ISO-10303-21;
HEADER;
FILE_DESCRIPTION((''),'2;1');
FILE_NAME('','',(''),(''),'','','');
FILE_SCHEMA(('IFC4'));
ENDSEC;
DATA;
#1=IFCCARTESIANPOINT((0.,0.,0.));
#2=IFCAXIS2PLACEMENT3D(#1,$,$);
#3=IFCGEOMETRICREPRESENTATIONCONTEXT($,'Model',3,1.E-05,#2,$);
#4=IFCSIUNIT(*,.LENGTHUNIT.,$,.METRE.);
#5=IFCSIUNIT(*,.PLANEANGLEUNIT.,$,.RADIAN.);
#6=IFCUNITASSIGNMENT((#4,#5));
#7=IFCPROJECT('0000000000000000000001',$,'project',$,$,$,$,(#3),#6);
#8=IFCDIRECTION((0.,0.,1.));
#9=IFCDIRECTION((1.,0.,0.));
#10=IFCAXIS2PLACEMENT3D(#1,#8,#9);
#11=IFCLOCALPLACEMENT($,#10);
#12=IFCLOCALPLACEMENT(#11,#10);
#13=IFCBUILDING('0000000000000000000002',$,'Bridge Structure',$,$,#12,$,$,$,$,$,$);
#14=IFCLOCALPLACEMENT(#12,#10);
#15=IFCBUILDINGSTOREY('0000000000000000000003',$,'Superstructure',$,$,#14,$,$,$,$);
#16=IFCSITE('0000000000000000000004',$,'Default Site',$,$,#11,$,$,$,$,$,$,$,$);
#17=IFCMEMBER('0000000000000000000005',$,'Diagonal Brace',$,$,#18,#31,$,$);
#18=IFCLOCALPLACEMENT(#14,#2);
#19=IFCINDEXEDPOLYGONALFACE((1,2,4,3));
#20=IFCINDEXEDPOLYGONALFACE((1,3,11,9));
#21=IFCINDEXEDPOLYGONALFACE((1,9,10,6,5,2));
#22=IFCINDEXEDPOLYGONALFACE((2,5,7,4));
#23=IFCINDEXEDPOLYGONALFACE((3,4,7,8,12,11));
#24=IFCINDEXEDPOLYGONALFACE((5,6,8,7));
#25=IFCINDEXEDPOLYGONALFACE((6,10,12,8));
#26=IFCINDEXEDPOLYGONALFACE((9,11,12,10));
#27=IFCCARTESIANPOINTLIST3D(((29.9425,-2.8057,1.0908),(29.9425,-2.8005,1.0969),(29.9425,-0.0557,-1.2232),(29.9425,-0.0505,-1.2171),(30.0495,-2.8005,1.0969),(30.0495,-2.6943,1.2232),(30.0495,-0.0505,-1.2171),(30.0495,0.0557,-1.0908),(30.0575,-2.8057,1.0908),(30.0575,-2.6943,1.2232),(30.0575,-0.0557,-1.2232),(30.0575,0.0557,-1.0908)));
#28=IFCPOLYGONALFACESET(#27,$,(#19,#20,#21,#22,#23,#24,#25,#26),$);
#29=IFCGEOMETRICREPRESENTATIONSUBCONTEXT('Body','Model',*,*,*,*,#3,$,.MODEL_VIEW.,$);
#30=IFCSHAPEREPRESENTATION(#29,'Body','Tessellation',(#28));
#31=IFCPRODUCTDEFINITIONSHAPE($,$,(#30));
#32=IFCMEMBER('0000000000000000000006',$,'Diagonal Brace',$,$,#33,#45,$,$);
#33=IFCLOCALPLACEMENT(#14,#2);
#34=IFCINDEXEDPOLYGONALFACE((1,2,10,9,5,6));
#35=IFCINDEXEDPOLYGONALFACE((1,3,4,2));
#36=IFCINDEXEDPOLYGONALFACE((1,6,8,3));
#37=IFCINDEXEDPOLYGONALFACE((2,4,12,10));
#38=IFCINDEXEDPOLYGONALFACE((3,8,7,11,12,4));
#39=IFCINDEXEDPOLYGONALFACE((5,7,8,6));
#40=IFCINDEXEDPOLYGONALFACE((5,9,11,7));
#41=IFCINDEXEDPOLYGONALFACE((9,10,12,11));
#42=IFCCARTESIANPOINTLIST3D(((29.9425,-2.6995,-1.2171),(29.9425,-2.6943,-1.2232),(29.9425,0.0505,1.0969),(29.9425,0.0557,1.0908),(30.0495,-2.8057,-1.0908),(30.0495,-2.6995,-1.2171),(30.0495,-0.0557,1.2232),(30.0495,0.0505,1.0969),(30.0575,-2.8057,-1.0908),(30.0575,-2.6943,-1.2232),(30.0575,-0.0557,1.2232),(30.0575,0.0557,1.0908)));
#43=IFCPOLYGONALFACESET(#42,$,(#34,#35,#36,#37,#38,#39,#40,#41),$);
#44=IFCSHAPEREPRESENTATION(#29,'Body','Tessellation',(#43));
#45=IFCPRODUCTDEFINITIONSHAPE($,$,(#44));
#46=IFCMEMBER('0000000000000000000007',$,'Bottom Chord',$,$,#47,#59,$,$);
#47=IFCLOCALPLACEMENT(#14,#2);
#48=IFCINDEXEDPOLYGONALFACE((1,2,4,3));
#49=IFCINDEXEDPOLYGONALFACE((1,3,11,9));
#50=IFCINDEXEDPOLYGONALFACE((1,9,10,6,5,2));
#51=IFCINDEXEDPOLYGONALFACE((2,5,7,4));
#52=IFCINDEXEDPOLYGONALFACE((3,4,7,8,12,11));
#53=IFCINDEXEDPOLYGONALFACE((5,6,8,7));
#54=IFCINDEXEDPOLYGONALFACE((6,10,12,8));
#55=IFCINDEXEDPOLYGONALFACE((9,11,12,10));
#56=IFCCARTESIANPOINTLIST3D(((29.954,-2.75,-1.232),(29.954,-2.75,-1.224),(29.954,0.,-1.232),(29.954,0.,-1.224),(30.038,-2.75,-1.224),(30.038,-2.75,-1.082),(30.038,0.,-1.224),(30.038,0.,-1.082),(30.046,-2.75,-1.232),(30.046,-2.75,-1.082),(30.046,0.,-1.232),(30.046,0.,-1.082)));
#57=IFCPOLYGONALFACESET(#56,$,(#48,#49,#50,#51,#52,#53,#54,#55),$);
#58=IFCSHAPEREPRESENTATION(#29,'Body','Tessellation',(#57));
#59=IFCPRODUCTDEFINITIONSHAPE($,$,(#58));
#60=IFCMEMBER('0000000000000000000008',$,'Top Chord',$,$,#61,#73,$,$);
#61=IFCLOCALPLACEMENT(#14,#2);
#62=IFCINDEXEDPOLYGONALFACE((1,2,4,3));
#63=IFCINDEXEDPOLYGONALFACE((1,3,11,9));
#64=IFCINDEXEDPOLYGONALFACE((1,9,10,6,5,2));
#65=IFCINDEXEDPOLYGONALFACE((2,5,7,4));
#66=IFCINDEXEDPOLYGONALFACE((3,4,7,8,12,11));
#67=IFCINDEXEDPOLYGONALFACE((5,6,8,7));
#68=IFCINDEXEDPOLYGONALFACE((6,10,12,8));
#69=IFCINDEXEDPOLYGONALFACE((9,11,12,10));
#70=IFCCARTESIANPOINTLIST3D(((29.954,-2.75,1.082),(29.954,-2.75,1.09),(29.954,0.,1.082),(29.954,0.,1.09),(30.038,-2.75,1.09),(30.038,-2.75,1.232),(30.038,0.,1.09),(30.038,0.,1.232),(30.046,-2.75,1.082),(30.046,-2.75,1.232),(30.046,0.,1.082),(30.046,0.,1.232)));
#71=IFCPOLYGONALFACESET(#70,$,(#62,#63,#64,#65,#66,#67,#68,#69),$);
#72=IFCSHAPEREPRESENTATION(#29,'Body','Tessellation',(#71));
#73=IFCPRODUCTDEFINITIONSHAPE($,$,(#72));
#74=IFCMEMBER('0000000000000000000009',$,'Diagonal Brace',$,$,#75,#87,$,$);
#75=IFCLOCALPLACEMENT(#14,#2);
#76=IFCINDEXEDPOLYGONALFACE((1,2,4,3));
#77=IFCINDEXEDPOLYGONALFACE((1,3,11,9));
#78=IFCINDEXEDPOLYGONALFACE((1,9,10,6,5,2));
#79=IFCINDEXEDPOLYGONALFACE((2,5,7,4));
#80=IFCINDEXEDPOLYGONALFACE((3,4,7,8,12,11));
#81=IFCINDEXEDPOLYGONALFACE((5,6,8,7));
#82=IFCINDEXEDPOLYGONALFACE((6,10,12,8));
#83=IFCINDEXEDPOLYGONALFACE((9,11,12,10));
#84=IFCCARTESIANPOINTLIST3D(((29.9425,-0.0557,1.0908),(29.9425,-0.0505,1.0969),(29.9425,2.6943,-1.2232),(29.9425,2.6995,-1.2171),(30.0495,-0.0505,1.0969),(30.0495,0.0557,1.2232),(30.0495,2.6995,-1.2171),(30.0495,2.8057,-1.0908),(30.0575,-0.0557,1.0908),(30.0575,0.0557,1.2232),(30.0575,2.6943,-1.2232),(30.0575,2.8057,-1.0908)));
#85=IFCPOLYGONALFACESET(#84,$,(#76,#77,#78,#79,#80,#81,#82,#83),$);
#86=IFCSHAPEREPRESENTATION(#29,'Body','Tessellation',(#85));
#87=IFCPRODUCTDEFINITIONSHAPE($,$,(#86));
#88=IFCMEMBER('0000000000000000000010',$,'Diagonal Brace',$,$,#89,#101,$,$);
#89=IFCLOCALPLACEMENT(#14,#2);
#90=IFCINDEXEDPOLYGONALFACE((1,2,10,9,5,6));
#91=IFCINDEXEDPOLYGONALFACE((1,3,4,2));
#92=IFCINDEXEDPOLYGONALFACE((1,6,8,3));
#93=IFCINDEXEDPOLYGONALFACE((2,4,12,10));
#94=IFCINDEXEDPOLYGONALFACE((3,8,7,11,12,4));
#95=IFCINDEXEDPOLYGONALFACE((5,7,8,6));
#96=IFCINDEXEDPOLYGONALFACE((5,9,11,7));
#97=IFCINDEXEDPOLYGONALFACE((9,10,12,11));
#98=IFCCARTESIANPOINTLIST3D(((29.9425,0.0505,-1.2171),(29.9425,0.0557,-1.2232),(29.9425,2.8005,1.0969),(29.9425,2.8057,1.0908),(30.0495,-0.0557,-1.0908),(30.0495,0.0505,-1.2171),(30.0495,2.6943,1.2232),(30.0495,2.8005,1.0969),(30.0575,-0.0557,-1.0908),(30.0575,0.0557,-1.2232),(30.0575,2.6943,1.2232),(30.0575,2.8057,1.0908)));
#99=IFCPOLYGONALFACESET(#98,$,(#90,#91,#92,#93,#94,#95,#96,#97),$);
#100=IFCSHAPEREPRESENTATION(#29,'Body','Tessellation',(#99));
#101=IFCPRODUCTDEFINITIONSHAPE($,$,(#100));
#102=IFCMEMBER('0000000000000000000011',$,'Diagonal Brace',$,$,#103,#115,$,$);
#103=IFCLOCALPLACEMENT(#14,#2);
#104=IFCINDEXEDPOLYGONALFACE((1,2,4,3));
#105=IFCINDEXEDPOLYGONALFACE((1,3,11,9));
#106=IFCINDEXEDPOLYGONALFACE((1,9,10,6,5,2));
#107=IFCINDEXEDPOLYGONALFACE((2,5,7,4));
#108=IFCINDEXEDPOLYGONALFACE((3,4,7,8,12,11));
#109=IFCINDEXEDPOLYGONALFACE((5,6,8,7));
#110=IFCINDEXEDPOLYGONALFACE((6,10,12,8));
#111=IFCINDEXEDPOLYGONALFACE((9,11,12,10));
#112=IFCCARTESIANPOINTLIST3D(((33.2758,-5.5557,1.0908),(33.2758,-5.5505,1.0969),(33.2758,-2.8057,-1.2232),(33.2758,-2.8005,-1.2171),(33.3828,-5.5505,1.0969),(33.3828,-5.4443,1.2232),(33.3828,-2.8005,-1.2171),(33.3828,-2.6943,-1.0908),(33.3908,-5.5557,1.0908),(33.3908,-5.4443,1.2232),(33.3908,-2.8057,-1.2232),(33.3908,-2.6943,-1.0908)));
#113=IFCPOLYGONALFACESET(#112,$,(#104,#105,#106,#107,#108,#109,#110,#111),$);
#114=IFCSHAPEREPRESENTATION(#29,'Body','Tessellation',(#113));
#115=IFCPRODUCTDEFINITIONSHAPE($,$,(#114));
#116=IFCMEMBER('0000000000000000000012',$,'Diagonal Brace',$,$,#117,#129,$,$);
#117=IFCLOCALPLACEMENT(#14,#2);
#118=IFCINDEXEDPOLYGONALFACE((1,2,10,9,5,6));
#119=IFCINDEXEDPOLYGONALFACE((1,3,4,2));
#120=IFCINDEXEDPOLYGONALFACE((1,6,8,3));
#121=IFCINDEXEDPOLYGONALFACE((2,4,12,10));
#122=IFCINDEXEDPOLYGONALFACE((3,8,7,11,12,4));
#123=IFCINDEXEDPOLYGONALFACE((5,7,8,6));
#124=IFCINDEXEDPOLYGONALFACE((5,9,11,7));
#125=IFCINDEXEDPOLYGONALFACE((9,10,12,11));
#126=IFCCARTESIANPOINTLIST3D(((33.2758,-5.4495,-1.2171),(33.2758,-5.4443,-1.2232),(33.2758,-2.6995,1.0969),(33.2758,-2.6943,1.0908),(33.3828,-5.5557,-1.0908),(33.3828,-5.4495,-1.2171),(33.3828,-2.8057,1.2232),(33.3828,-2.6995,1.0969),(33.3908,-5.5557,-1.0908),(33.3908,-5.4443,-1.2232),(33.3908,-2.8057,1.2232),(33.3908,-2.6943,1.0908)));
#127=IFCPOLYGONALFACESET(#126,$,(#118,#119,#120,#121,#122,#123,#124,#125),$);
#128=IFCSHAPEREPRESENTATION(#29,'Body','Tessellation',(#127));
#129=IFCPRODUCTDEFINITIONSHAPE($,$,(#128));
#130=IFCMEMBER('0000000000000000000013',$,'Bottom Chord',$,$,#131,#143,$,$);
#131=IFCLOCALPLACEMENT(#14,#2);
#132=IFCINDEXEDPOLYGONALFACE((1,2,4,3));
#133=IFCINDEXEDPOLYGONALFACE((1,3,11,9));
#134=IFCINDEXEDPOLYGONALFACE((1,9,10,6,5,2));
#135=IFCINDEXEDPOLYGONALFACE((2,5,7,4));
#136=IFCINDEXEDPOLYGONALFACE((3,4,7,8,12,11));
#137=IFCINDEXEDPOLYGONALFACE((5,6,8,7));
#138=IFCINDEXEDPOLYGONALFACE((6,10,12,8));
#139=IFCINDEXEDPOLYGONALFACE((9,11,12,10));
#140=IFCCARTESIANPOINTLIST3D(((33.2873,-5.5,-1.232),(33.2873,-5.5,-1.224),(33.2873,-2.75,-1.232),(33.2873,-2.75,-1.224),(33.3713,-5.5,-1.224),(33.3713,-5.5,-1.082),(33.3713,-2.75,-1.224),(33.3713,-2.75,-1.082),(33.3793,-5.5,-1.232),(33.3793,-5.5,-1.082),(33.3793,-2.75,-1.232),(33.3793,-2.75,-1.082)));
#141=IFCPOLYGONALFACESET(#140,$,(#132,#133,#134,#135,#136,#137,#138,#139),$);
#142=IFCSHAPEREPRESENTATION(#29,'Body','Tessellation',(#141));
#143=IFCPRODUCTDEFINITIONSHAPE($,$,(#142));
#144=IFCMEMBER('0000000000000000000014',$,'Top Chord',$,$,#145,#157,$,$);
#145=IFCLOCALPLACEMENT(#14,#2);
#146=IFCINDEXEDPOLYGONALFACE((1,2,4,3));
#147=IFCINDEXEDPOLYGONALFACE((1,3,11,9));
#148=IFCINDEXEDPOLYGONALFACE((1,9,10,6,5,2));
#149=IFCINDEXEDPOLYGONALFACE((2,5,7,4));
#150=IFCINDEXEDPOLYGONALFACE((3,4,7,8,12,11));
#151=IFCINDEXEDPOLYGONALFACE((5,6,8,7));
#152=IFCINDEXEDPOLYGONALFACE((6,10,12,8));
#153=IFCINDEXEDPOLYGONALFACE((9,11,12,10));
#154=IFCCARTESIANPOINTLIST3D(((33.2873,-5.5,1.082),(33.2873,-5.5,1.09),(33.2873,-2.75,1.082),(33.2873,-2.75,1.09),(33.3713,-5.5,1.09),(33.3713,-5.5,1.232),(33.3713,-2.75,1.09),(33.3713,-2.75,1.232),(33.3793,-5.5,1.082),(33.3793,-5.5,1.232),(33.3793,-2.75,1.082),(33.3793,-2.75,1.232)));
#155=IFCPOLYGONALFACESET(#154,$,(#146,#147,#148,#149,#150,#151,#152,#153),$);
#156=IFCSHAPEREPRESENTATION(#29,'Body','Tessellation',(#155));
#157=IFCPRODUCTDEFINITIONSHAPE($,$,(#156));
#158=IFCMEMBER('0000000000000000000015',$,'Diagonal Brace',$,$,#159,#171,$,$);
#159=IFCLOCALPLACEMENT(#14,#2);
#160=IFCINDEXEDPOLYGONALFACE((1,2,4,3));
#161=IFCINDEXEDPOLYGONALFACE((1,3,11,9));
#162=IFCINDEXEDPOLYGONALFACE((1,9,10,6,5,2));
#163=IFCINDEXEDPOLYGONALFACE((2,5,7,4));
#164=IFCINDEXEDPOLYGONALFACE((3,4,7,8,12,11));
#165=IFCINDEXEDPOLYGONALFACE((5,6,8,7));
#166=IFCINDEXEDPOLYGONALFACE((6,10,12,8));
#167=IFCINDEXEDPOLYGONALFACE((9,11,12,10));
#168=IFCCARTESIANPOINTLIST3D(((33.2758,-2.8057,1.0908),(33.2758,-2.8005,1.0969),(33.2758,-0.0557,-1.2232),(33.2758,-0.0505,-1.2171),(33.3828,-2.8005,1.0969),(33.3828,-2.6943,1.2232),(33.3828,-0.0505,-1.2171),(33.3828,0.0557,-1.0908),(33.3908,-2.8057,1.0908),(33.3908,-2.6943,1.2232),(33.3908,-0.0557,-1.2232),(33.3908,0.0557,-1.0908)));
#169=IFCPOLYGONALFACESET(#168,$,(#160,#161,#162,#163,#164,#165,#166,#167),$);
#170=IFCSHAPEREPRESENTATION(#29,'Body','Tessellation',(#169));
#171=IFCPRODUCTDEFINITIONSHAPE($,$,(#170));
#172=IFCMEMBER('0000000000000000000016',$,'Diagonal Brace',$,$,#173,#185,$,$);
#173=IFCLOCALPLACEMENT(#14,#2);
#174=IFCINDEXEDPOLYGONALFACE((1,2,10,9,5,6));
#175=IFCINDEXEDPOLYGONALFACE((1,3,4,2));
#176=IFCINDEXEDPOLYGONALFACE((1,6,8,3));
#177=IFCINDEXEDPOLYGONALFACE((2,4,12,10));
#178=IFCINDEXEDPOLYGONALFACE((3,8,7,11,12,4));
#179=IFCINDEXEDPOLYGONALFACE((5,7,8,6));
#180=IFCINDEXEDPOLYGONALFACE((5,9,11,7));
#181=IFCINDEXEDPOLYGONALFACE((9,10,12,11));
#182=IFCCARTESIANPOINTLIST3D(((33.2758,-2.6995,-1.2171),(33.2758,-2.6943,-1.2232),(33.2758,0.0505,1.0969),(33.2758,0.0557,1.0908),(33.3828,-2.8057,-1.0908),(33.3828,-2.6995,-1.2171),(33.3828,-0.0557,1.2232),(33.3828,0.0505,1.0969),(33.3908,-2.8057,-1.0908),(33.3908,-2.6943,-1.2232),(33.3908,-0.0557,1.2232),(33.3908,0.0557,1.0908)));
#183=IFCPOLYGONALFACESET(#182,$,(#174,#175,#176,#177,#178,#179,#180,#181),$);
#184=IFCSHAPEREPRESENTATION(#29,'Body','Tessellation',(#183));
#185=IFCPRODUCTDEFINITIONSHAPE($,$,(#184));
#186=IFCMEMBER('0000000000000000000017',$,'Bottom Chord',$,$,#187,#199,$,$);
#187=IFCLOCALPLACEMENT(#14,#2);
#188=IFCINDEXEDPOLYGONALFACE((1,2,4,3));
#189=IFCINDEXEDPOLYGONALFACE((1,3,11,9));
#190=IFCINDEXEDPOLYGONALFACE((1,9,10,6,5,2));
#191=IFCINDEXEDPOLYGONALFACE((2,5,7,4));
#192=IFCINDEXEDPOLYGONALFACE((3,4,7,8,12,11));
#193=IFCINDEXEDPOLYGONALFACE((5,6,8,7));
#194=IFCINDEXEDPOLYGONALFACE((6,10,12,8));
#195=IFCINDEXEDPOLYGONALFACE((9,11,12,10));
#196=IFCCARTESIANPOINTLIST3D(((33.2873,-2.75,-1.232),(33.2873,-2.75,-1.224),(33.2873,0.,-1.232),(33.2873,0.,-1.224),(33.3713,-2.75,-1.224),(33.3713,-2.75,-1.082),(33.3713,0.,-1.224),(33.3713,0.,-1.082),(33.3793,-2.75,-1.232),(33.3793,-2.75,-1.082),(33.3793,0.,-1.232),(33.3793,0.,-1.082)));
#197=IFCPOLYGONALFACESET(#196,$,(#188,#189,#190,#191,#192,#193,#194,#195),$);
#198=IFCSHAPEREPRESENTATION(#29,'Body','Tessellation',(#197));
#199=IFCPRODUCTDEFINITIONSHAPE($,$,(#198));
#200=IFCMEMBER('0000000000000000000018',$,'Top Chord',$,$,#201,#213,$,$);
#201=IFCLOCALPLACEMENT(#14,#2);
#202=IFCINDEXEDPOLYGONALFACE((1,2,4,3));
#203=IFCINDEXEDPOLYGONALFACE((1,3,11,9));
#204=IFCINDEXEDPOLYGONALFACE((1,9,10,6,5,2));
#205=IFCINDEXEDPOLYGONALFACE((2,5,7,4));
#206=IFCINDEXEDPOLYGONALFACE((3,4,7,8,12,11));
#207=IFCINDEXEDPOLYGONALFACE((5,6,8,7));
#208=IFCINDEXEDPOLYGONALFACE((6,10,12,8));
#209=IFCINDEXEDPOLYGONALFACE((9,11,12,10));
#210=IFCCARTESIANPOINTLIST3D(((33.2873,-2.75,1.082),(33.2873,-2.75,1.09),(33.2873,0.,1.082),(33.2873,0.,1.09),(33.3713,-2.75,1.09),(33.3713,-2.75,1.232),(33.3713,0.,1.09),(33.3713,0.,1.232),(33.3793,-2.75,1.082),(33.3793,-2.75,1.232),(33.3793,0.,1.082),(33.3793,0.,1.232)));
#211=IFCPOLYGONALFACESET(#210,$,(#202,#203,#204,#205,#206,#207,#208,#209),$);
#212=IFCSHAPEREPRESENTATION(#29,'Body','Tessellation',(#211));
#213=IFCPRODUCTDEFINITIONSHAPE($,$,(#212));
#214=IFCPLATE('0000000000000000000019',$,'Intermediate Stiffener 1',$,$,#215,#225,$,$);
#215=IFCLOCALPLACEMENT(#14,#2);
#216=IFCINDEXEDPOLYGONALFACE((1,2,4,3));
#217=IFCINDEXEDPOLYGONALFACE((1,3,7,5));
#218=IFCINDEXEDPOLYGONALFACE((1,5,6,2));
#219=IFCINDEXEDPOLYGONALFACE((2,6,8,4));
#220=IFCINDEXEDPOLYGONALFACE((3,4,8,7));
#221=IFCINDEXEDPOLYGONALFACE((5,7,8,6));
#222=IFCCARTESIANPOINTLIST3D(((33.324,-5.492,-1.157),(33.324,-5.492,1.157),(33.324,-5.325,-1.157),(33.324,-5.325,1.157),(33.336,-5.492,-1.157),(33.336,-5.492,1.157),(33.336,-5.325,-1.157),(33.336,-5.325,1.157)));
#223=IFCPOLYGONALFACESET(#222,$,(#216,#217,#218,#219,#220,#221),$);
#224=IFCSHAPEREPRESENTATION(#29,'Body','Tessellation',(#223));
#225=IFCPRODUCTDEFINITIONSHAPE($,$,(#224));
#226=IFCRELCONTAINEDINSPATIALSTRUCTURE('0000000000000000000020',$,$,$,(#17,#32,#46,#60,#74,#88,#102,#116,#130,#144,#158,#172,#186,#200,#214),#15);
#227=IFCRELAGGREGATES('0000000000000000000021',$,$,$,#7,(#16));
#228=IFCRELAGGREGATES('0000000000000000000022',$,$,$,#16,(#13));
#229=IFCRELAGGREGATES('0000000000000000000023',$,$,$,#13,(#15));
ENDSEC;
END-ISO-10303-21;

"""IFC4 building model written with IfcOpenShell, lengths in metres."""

from ifc_helpers import new_model, si_unit, frame, origin, origin_with_axes, origin_2d_with_axis, place, context, subcontext, project, spatial, rectangle, l_section, extrude, element, save


model = new_model("IFC4")

# Units and contexts
model_context = context("Model", 3, precision=1e-05, world=origin())
body_context = subcontext(model_context, "Body", "Model", "MODEL_VIEW")
ifc_project = project(units=[si_unit("LENGTHUNIT", "METRE"), si_unit("PLANEANGLEUNIT", "RADIAN")], contexts=[model_context])

# Site, building, storey
site_placement = place(None, origin_with_axes())
site = spatial("IfcSite", under=ifc_project, at=site_placement, Name="Default Site")
building_placement = place(site_placement, origin_with_axes())
building = spatial("IfcBuilding", under=site, at=building_placement, Name="Bridge Structure")
storey_placement = place(building_placement, origin_with_axes())
storey = spatial("IfcBuildingStorey", under=building, at=storey_placement, Name="Superstructure")

# Members
for number, where, z_axis, x_axis, name in (
    (1, (30.0, -2.75, 1.157), (0.0, 0.765156, -0.643844), (-1.0, 0.0, 0.0), "Diagonal Brace"),
    (2, (30.0, -2.75, -1.157), (0.0, 0.765156, 0.643844), (-1.0, 0.0, 0.0), "Diagonal Brace"),
):
    element("IfcMember", number, at=place(storey_placement, frame(where, z_axis=z_axis, x_axis=x_axis)), inside=storey, Name=name, context=body_context, shape_type="SweptSolid", body=[
        extrude(l_section(Depth=0.173, Width=0.115, Thickness=0.008, at=origin_2d_with_axis()), origin_with_axes(), (0.0, 0.0, 1.0), 3.594),
    ])
for number, where, z_axis, x_axis, name in (
    (3, (30.0, -2.75, -1.157), (0.0, 1.0, 0.0), (-1.0, 0.0, 0.0), "Bottom Chord"),
    (4, (30.0, -2.75, 1.157), (0.0, 1.0, 0.0), (-1.0, 0.0, 0.0), "Top Chord"),
):
    element("IfcMember", number, at=place(storey_placement, frame(where, z_axis=z_axis, x_axis=x_axis)), inside=storey, Name=name, context=body_context, shape_type="SweptSolid", body=[
        extrude(l_section(Depth=0.15, Width=0.092, Thickness=0.008, at=origin_2d_with_axis()), origin_with_axes(), (0.0, 0.0, 1.0), 2.75),
    ])
for number, where, z_axis, x_axis, name in (
    (5, (30.0, 0.0, 1.157), (0.0, 0.765156, -0.643844), (-1.0, 0.0, 0.0), "Diagonal Brace"),
    (6, (30.0, 0.0, -1.157), (0.0, 0.765156, 0.643844), (-1.0, 0.0, 0.0), "Diagonal Brace"),
    (7, (33.3333, -5.5, 1.157), (0.0, 0.765156, -0.643844), (-1.0, 0.0, 0.0), "Diagonal Brace"),
    (8, (33.3333, -5.5, -1.157), (0.0, 0.765156, 0.643844), (-1.0, 0.0, 0.0), "Diagonal Brace"),
):
    element("IfcMember", number, at=place(storey_placement, frame(where, z_axis=z_axis, x_axis=x_axis)), inside=storey, Name=name, context=body_context, shape_type="SweptSolid", body=[
        extrude(l_section(Depth=0.173, Width=0.115, Thickness=0.008, at=origin_2d_with_axis()), origin_with_axes(), (0.0, 0.0, 1.0), 3.594),
    ])
for number, where, z_axis, x_axis, name in (
    (9, (33.3333, -5.5, -1.157), (0.0, 1.0, 0.0), (-1.0, 0.0, 0.0), "Bottom Chord"),
    (10, (33.3333, -5.5, 1.157), (0.0, 1.0, 0.0), (-1.0, 0.0, 0.0), "Top Chord"),
):
    element("IfcMember", number, at=place(storey_placement, frame(where, z_axis=z_axis, x_axis=x_axis)), inside=storey, Name=name, context=body_context, shape_type="SweptSolid", body=[
        extrude(l_section(Depth=0.15, Width=0.092, Thickness=0.008, at=origin_2d_with_axis()), origin_with_axes(), (0.0, 0.0, 1.0), 2.75),
    ])
for number, where, z_axis, x_axis, name in (
    (11, (33.3333, -2.75, 1.157), (0.0, 0.765156, -0.643844), (-1.0, 0.0, 0.0), "Diagonal Brace"),
    (12, (33.3333, -2.75, -1.157), (0.0, 0.765156, 0.643844), (-1.0, 0.0, 0.0), "Diagonal Brace"),
):
    element("IfcMember", number, at=place(storey_placement, frame(where, z_axis=z_axis, x_axis=x_axis)), inside=storey, Name=name, context=body_context, shape_type="SweptSolid", body=[
        extrude(l_section(Depth=0.173, Width=0.115, Thickness=0.008, at=origin_2d_with_axis()), origin_with_axes(), (0.0, 0.0, 1.0), 3.594),
    ])
for number, where, z_axis, x_axis, name in (
    (13, (33.3333, -2.75, -1.157), (0.0, 1.0, 0.0), (-1.0, 0.0, 0.0), "Bottom Chord"),
    (14, (33.3333, -2.75, 1.157), (0.0, 1.0, 0.0), (-1.0, 0.0, 0.0), "Top Chord"),
):
    element("IfcMember", number, at=place(storey_placement, frame(where, z_axis=z_axis, x_axis=x_axis)), inside=storey, Name=name, context=body_context, shape_type="SweptSolid", body=[
        extrude(l_section(Depth=0.15, Width=0.092, Thickness=0.008, at=origin_2d_with_axis()), origin_with_axes(), (0.0, 0.0, 1.0), 2.75),
    ])

# Plate
for number, where, z_axis, x_axis, name in (
    (15, (33.33, -5.4085, -1.157), (0.0, 0.0, 1.0), (1.0, 0.0, 0.0), "Intermediate Stiffener 1"),
):
    element("IfcPlate", number, at=place(storey_placement, frame(where, z_axis=z_axis, x_axis=x_axis)), inside=storey, Name=name, context=body_context, shape_type="SweptSolid", body=[
        extrude(rectangle(XDim=0.012, YDim=0.167, at=origin_2d_with_axis()), origin_with_axes(), (0.0, 0.0, 1.0), 2.314),
    ])

save(model, "model.ifc")
